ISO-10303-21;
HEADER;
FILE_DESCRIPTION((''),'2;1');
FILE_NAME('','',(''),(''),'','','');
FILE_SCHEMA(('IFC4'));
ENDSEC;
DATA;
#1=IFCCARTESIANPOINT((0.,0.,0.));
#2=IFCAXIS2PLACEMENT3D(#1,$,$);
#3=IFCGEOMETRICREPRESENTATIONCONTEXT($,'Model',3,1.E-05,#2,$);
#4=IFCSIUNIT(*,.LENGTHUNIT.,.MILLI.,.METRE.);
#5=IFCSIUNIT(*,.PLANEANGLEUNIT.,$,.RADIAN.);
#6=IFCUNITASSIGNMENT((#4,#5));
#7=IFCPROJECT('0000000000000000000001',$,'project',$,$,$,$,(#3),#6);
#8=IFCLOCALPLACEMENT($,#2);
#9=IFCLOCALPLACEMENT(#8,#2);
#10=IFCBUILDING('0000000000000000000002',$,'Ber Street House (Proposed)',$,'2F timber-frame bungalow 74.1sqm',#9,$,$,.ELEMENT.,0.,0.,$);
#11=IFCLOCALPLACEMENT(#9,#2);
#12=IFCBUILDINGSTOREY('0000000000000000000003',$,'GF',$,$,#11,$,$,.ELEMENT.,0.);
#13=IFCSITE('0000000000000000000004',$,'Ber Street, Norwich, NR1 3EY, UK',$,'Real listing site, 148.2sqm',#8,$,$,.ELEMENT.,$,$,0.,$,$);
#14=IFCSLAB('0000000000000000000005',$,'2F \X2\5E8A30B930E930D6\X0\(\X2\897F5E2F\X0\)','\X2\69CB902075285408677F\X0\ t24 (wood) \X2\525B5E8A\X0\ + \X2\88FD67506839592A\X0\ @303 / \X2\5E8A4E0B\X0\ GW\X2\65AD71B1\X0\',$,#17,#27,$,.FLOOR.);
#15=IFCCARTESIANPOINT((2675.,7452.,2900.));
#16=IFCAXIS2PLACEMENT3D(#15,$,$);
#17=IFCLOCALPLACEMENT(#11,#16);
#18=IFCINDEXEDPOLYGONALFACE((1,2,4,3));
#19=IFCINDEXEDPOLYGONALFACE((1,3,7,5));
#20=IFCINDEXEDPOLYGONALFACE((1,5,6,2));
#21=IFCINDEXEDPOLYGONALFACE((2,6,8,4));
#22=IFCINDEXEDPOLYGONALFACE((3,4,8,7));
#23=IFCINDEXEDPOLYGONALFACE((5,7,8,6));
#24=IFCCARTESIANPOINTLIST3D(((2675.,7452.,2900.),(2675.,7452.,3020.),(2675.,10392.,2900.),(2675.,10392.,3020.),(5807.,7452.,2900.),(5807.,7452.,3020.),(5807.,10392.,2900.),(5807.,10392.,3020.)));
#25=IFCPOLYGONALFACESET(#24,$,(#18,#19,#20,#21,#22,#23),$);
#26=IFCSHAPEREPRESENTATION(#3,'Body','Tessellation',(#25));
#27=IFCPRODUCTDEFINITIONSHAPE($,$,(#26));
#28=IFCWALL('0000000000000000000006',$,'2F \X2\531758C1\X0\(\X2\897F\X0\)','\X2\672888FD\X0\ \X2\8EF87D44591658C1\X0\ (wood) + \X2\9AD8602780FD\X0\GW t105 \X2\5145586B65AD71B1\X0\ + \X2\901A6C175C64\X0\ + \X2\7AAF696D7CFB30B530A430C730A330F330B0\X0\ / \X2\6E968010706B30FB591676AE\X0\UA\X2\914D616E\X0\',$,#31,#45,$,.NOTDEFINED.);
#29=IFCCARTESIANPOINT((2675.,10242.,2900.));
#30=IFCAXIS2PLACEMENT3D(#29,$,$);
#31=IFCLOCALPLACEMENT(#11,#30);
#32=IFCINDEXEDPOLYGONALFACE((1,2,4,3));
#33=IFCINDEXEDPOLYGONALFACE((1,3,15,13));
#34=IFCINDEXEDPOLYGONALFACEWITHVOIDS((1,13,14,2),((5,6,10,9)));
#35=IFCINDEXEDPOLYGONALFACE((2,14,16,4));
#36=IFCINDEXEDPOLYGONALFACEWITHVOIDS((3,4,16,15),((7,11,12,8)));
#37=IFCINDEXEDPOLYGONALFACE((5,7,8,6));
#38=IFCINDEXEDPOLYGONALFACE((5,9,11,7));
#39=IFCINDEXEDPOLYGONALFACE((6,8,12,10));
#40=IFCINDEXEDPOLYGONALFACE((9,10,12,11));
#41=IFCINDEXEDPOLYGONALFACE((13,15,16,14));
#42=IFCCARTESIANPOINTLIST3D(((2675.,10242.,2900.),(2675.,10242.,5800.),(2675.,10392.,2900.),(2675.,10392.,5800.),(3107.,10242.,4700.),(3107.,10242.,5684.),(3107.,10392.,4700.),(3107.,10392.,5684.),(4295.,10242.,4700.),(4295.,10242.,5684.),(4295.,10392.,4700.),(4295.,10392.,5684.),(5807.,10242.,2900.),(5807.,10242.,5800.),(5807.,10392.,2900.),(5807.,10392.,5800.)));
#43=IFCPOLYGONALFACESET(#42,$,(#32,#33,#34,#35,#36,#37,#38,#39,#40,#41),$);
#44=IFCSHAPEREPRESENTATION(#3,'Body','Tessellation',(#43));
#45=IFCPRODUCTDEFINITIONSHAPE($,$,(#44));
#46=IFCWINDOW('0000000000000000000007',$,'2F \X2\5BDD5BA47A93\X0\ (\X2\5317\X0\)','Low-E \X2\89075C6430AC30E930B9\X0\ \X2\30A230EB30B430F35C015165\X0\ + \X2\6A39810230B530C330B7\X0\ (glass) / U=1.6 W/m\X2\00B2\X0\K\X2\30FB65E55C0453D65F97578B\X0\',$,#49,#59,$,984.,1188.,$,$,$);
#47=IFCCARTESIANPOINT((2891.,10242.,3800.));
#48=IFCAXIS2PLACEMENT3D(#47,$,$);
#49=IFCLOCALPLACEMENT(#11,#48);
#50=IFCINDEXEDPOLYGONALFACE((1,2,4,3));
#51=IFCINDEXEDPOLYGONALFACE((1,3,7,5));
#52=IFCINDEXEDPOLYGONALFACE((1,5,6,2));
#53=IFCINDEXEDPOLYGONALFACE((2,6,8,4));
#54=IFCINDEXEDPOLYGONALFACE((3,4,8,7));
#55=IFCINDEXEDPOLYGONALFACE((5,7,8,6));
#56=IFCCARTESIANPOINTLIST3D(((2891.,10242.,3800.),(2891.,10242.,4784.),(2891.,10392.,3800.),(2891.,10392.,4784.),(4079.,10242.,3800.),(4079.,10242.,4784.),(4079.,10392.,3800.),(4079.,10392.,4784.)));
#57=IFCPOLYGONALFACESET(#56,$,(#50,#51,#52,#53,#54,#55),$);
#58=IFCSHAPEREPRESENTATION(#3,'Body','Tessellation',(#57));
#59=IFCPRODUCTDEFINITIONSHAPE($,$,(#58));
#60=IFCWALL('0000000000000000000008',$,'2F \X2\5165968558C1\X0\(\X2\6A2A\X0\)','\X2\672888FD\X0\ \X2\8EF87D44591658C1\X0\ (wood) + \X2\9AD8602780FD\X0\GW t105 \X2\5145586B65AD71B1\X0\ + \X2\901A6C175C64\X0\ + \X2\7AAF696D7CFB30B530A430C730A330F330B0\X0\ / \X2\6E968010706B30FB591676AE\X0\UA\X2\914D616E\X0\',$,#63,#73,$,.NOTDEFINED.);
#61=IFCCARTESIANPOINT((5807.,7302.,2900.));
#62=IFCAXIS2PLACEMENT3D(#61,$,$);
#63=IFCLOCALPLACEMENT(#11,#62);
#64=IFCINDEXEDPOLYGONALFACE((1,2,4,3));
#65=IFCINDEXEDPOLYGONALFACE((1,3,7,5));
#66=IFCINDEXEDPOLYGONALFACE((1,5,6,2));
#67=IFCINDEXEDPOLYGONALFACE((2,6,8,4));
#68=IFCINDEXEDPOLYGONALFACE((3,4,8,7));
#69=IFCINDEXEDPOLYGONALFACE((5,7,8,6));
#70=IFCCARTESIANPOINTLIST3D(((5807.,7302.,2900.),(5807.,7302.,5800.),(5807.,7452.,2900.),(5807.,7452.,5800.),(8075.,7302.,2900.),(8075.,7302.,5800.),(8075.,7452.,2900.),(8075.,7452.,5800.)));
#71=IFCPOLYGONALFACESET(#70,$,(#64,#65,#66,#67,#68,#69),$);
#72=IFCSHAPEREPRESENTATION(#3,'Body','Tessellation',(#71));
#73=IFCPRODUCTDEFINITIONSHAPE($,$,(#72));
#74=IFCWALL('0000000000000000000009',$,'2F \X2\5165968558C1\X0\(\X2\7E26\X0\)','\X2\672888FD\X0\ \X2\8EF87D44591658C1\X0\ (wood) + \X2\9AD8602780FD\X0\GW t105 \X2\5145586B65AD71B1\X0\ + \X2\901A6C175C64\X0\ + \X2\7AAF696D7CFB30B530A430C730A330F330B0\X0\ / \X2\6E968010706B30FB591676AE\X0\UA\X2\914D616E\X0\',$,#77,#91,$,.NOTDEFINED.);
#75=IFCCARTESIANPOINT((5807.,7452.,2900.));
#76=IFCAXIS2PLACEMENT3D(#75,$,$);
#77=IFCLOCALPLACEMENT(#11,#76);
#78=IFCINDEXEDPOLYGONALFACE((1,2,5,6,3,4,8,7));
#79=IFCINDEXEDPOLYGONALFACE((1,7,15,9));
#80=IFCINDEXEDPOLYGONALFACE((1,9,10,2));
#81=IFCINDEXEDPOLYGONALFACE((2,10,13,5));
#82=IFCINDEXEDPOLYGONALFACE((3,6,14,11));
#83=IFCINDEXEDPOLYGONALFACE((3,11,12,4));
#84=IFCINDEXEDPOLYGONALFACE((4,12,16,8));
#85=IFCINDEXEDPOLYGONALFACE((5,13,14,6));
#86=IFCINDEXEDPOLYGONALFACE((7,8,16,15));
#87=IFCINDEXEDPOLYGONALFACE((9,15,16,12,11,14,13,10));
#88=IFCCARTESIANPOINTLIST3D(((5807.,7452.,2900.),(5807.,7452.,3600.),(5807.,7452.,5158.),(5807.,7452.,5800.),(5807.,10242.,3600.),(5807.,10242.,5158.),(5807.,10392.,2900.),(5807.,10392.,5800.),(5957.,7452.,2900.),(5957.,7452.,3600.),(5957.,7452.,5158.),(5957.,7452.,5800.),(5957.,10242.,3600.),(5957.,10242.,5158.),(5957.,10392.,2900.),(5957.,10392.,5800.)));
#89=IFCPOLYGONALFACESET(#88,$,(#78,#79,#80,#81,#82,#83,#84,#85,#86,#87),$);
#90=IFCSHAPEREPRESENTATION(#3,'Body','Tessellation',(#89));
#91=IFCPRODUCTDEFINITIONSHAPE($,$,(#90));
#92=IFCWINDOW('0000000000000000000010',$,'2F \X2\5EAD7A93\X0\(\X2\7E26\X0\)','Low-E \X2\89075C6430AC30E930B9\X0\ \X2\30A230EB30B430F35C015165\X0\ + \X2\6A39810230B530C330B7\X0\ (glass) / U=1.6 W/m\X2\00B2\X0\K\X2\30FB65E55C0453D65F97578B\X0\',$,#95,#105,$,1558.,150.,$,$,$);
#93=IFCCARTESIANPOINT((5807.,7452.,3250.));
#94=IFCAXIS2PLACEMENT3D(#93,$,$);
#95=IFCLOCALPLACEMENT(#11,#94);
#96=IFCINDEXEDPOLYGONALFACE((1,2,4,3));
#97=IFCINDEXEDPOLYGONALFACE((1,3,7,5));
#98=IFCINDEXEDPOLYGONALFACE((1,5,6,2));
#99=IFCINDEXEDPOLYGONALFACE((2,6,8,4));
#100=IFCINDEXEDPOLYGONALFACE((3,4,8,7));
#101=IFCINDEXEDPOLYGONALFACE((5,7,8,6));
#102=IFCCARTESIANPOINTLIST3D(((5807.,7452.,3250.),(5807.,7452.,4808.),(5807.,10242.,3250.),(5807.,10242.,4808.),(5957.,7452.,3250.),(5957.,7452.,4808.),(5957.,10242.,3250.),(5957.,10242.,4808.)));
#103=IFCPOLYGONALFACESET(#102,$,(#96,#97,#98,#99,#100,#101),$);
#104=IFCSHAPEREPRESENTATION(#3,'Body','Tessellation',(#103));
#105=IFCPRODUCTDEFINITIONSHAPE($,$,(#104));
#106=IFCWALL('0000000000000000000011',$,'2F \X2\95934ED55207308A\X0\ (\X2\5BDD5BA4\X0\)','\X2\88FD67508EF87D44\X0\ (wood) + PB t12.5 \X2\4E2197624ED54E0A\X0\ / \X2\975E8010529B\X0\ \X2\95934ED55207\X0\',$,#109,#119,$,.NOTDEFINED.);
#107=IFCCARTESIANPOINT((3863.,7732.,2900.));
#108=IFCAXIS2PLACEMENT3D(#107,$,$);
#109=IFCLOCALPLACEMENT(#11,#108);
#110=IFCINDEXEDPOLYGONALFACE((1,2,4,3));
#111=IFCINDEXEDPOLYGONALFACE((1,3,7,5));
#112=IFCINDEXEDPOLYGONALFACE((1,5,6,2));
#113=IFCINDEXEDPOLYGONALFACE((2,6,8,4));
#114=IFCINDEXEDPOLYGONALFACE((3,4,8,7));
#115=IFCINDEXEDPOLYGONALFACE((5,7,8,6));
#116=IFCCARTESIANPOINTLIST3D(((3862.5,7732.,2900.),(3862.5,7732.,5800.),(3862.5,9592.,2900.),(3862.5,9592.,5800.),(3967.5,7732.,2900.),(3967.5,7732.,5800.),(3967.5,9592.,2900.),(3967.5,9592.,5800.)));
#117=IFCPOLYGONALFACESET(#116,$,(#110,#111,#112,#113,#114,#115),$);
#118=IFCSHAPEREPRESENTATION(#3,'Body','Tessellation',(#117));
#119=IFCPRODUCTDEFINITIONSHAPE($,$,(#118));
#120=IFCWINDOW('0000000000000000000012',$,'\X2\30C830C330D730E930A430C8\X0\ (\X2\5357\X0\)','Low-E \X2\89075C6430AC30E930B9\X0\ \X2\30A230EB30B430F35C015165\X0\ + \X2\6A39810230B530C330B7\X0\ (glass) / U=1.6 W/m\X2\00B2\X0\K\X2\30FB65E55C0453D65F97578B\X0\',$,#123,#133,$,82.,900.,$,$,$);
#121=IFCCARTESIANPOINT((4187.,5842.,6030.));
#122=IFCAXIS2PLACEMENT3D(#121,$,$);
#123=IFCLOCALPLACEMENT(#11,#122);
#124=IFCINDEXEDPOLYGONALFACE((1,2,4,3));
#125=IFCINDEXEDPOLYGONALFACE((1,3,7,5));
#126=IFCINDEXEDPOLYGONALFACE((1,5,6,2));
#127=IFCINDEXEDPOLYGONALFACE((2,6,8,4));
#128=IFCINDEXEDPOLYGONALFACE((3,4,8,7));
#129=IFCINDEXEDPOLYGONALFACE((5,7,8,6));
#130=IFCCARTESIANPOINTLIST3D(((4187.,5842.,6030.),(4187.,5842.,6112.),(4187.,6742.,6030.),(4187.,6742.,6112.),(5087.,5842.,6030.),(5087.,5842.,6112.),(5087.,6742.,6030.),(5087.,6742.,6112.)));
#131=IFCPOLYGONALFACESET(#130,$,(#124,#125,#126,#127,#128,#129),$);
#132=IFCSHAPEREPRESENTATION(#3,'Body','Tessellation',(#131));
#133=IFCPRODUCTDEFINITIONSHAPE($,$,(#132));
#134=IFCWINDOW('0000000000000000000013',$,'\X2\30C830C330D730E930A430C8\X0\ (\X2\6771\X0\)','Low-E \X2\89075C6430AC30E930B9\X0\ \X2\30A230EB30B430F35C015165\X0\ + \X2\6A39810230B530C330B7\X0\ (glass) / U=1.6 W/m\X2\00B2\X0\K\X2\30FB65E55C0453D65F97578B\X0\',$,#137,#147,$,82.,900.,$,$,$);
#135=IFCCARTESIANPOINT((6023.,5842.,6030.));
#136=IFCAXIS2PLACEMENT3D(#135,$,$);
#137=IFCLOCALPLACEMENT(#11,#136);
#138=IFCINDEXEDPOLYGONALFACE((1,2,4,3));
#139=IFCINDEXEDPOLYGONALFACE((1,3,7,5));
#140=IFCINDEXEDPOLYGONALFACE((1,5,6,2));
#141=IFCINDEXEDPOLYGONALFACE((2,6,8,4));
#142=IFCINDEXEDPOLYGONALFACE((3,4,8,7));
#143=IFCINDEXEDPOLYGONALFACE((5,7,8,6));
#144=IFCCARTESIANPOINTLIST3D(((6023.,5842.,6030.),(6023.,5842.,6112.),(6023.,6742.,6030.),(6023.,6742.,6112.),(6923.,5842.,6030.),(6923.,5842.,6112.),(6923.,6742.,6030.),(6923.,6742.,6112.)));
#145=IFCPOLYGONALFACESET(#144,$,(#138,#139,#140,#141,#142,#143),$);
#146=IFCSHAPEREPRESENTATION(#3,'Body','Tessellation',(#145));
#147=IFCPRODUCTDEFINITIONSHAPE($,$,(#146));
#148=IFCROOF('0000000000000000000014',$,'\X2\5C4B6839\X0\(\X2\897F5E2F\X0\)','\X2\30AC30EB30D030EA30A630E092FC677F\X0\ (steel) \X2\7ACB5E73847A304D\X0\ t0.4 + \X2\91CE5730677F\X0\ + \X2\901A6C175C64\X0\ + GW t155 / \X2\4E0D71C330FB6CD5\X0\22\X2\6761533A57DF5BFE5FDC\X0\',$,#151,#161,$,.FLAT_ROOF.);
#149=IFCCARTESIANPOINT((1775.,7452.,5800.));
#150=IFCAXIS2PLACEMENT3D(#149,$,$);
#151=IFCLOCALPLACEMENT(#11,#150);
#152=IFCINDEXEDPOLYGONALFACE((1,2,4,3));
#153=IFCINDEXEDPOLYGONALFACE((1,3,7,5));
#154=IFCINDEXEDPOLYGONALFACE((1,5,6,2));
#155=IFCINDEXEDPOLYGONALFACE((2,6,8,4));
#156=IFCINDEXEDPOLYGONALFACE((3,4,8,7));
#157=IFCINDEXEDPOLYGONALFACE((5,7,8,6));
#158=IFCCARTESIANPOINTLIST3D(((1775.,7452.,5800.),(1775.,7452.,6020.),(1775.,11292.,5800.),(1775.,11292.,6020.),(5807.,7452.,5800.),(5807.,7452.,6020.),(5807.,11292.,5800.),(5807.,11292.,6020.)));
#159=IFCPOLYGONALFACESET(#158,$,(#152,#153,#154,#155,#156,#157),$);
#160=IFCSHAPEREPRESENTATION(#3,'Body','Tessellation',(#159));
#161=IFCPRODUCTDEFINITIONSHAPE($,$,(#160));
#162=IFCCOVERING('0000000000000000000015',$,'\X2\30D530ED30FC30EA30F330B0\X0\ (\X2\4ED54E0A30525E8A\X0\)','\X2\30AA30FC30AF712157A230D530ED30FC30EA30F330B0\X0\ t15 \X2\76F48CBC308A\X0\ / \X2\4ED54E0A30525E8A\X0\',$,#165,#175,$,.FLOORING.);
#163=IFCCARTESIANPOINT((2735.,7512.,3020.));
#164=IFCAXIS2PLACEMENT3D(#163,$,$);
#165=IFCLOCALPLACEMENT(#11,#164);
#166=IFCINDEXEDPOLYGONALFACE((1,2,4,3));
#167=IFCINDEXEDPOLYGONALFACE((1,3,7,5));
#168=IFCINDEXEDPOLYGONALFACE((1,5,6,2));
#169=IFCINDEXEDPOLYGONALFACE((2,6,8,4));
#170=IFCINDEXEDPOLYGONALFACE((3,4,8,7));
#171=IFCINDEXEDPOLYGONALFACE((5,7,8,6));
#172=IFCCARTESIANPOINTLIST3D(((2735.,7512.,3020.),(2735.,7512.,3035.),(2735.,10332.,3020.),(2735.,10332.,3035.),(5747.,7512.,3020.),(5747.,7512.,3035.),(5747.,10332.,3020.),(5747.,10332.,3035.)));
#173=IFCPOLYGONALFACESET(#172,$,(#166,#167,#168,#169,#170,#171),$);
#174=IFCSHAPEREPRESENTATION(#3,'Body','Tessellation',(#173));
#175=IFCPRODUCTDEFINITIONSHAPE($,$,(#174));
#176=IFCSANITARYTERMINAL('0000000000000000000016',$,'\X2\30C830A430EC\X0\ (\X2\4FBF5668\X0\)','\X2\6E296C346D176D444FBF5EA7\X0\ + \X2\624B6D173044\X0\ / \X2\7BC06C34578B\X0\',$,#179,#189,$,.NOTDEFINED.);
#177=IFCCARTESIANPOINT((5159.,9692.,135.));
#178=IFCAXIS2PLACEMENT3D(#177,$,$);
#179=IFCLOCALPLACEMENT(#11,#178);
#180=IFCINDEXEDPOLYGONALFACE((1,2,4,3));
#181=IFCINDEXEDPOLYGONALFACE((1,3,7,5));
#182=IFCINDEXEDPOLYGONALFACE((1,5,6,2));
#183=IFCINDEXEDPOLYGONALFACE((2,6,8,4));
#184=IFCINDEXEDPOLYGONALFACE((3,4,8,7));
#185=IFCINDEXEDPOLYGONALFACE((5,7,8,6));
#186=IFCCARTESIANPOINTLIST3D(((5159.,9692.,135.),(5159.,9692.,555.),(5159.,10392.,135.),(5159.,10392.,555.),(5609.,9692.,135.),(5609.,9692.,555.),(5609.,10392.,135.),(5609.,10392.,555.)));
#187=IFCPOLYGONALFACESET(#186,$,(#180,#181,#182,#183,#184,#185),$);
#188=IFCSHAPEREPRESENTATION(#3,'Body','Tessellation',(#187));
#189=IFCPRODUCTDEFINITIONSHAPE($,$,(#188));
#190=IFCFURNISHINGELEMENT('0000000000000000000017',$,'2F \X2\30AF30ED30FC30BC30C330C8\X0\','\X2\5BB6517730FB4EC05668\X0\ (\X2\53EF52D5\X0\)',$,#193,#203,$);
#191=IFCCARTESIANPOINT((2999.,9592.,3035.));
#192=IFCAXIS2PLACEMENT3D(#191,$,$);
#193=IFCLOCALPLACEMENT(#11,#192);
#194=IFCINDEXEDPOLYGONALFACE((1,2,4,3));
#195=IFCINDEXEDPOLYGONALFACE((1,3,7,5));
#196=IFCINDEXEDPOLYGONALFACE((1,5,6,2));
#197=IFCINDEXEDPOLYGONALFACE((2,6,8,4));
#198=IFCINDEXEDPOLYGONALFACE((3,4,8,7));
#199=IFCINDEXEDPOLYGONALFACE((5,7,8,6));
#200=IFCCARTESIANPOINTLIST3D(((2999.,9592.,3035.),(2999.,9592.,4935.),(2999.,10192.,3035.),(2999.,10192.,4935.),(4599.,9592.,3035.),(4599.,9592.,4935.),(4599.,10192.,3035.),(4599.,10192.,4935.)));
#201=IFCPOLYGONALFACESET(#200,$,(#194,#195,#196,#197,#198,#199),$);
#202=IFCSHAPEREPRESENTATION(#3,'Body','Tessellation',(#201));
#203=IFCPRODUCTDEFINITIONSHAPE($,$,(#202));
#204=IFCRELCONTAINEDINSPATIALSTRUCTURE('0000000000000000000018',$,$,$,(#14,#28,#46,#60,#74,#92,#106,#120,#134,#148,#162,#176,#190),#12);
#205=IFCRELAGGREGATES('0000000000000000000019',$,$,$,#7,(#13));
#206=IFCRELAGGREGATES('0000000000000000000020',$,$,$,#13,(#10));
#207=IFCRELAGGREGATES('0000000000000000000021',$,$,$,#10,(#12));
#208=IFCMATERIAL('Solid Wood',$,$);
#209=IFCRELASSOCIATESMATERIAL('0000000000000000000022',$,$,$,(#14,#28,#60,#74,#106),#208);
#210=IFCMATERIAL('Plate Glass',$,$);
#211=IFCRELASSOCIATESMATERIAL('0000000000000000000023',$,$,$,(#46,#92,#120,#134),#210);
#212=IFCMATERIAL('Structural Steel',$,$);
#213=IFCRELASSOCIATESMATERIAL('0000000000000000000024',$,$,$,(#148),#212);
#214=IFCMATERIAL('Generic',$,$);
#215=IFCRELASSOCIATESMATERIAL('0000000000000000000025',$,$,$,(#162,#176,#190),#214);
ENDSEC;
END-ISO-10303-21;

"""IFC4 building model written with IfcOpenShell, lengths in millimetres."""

from ifc_helpers import new_model, si_unit, frame, frame_2d, origin, place, context, project, spatial, rectangle, extrude, material, element, fill, save


model = new_model("IFC4")

# Units and contexts
model_context = context("Model", 3, precision=1e-05, world=origin())
ifc_project = project(units=[si_unit("LENGTHUNIT", "METRE", prefix="MILLI"), si_unit("PLANEANGLEUNIT", "RADIAN")], contexts=[model_context])

# Site, building, storey
site_placement = place(None, origin())
site = spatial("IfcSite", under=ifc_project, at=site_placement, Name="Ber Street, Norwich, NR1 3EY, UK", ObjectType="Real listing site, 148.2sqm", CompositionType="ELEMENT", RefElevation=0.0)
building_placement = place(site_placement, origin())
building = spatial("IfcBuilding", under=site, at=building_placement, Name="Ber Street House (Proposed)", ObjectType="2F timber-frame bungalow 74.1sqm", CompositionType="ELEMENT", ElevationOfRefHeight=0.0, ElevationOfTerrain=0.0)
storey_placement = place(building_placement, origin())
storey = spatial("IfcBuildingStorey", under=building, at=storey_placement, Name="GF", CompositionType="ELEMENT", Elevation=0.0)

# Slab
ifc_material_1 = material(Name="Solid Wood")
slab_placement = place(storey_placement, frame((2675.0, 7452.0, 2900.0)))
element("IfcSlab", 1, at=slab_placement, inside=storey, material=ifc_material_1, Name="2F 床スラブ(西帯)", Description="構造用合板 t24 (wood) 剛床 + 製材根太 @303 / 床下 GW断熱", PredefinedType="FLOOR", context=model_context, shape_type="SweptSolid", body=[
    extrude(rectangle(XDim=3132.0, YDim=2940.0, at=frame_2d((1566.0, 1470.0))), frame((2675.0, 7452.0, 2900.0)), (0.0, 0.0, 1.0), 120.0),
])

# Wall, opening, window
wall_1_placement = place(storey_placement, frame((2675.0, 10242.0, 2900.0)))
wall_1 = element("IfcWall", 2, at=wall_1_placement, inside=storey, material=ifc_material_1, Name="2F 北壁(西)", Description="木製 軸組外壁 (wood) + 高性能GW t105 充填断熱 + 通気層 + 窯業系サイディング / 準耐火・外皮UA配慮", PredefinedType="NOTDEFINED", context=model_context, shape_type="SweptSolid", body=[
    extrude(rectangle(XDim=3132.0, YDim=150.0, at=frame_2d((1566.0, 75.0))), frame((2675.0, 10242.0, 2900.0)), (0.0, 0.0, 1.0), 2900.0),
])
opening_1_placement = place(storey_placement, frame((2891.0, 10242.0, 3800.0)))
opening_1 = element("IfcOpeningElement", 3, at=opening_1_placement, cuts=wall_1, PredefinedType="NOTDEFINED", context=model_context, shape_type="SweptSolid", body=[
    extrude(rectangle(XDim=1188.0, YDim=150.0, at=frame_2d((594.0, 75.0))), frame((2891.0, 10242.0, 3800.0)), (0.0, 0.0, 1.0), 984.0),
])
ifc_material_2 = material(Name="Plate Glass")
window_1_placement = place(storey_placement, frame((2891.0, 10242.0, 3800.0)))
window_1 = element("IfcWindow", 4, at=window_1_placement, inside=storey, material=ifc_material_2, Name="2F 寝室窓 (北)", Description="Low-E 複層ガラス アルゴン封入 + 樹脂サッシ (glass) / U=1.6 W/m²K・日射取得型", OverallHeight=984.0, OverallWidth=1188.0, context=model_context, shape_type="SweptSolid", body=[
    extrude(rectangle(XDim=1188.0, YDim=150.0, at=frame_2d((594.0, 75.0))), frame((2891.0, 10242.0, 3800.0)), (0.0, 0.0, 1.0), 984.0),
])
fill(opening_1, window_1)

# Wall
wall_2_placement = place(storey_placement, frame((5807.0, 7302.0, 2900.0)))
element("IfcWall", 5, at=wall_2_placement, inside=storey, material=ifc_material_1, Name="2F 入隅壁(横)", Description="木製 軸組外壁 (wood) + 高性能GW t105 充填断熱 + 通気層 + 窯業系サイディング / 準耐火・外皮UA配慮", PredefinedType="NOTDEFINED", context=model_context, shape_type="SweptSolid", body=[
    extrude(rectangle(XDim=2268.0, YDim=150.0, at=frame_2d((1134.0, 75.0))), frame((5807.0, 7302.0, 2900.0)), (0.0, 0.0, 1.0), 2900.0),
])

# Wall, opening, window
wall_3_placement = place(storey_placement, frame((5807.0, 7452.0, 2900.0)))
wall_3 = element("IfcWall", 6, at=wall_3_placement, inside=storey, material=ifc_material_1, Name="2F 入隅壁(縦)", Description="木製 軸組外壁 (wood) + 高性能GW t105 充填断熱 + 通気層 + 窯業系サイディング / 準耐火・外皮UA配慮", PredefinedType="NOTDEFINED", context=model_context, shape_type="SweptSolid", body=[
    extrude(rectangle(XDim=150.0, YDim=2940.0, at=frame_2d((75.0, 1470.0))), frame((5807.0, 7452.0, 2900.0)), (0.0, 0.0, 1.0), 2900.0),
])
opening_2_placement = place(storey_placement, frame((5807.0, 7452.0, 3250.0)))
opening_2 = element("IfcOpeningElement", 7, at=opening_2_placement, cuts=wall_3, PredefinedType="NOTDEFINED", context=model_context, shape_type="SweptSolid", body=[
    extrude(rectangle(XDim=150.0, YDim=2790.0, at=frame_2d((75.0, 1395.0))), frame((5807.0, 7452.0, 3250.0)), (0.0, 0.0, 1.0), 1558.0),
])
window_2_placement = place(storey_placement, frame((5807.0, 7452.0, 3250.0)))
window_2 = element("IfcWindow", 8, at=window_2_placement, inside=storey, material=ifc_material_2, Name="2F 庭窓(縦)", Description="Low-E 複層ガラス アルゴン封入 + 樹脂サッシ (glass) / U=1.6 W/m²K・日射取得型", OverallHeight=1558.0, OverallWidth=150.0, context=model_context, shape_type="SweptSolid", body=[
    extrude(rectangle(XDim=150.0, YDim=2790.0, at=frame_2d((75.0, 1395.0))), frame((5807.0, 7452.0, 3250.0)), (0.0, 0.0, 1.0), 1558.0),
])
fill(opening_2, window_2)

# Wall
wall_4_placement = place(storey_placement, frame((3863.0, 7732.0, 2900.0)))
element("IfcWall", 9, at=wall_4_placement, inside=storey, material=ifc_material_1, Name="2F 間仕切り (寝室)", Description="製材軸組 (wood) + PB t12.5 両面仕上 / 非耐力 間仕切", PredefinedType="NOTDEFINED", context=model_context, shape_type="SweptSolid", body=[
    extrude(rectangle(XDim=105.0, YDim=1860.0, at=frame_2d((52.0, 930.0))), frame((3863.0, 7732.0, 2900.0)), (0.0, 0.0, 1.0), 2900.0),
])

# Windows
window_3_placement = place(storey_placement, frame((4187.0, 5842.0, 6030.0)))
element("IfcWindow", 10, at=window_3_placement, inside=storey, material=ifc_material_2, Name="トップライト (南)", Description="Low-E 複層ガラス アルゴン封入 + 樹脂サッシ (glass) / U=1.6 W/m²K・日射取得型", OverallHeight=82.0, OverallWidth=900.0, context=model_context, shape_type="SweptSolid", body=[
    extrude(rectangle(XDim=900.0, YDim=900.0, at=frame_2d((450.0, 450.0))), frame((4187.0, 5842.0, 6030.0)), (0.0, 0.0, 1.0), 82.0),
])
window_4_placement = place(storey_placement, frame((6023.0, 5842.0, 6030.0)))
element("IfcWindow", 11, at=window_4_placement, inside=storey, material=ifc_material_2, Name="トップライト (東)", Description="Low-E 複層ガラス アルゴン封入 + 樹脂サッシ (glass) / U=1.6 W/m²K・日射取得型", OverallHeight=82.0, OverallWidth=900.0, context=model_context, shape_type="SweptSolid", body=[
    extrude(rectangle(XDim=900.0, YDim=900.0, at=frame_2d((450.0, 450.0))), frame((6023.0, 5842.0, 6030.0)), (0.0, 0.0, 1.0), 82.0),
])

# Roof
ifc_material_3 = material(Name="Structural Steel")
for number, where, name in (
    (12, (1775.0, 7452.0, 5800.0), "屋根(西帯)"),
):
    element("IfcRoof", number, at=place(storey_placement, frame(where)), inside=storey, material=ifc_material_3, Name=name, Description="ガルバリウム鋼板 (steel) 立平葺き t0.4 + 野地板 + 通気層 + GW t155 / 不燃・法22条区域対応", PredefinedType="FLAT_ROOF", context=model_context, shape_type="SweptSolid", body=[
        extrude(rectangle(XDim=4032.0, YDim=3840.0, at=frame_2d((2016.0, 1920.0))), frame((1775.0, 7452.0, 5800.0)), (0.0, 0.0, 1.0), 220.0),
    ])

# Covering
ifc_material_4 = material(Name="Generic")
covering_placement = place(storey_placement, frame((2735.0, 7512.0, 3020.0)))
element("IfcCovering", 13, at=covering_placement, inside=storey, material=ifc_material_4, Name="フローリング (仕上げ床)", Description="オーク無垢フローリング t15 直貼り / 仕上げ床", PredefinedType="FLOORING", context=model_context, shape_type="SweptSolid", body=[
    extrude(rectangle(XDim=3012.0, YDim=2820.0, at=frame_2d((1506.0, 1410.0))), frame((2735.0, 7512.0, 3020.0)), (0.0, 0.0, 1.0), 15.0),
])

# Sanitary terminal
sanitary_terminal_placement = place(storey_placement, frame((5159.0, 9692.0, 135.0)))
element("IfcSanitaryTerminal", 14, at=sanitary_terminal_placement, inside=storey, material=ifc_material_4, Name="トイレ (便器)", Description="温水洗浄便座 + 手洗い / 節水型", PredefinedType="NOTDEFINED", context=model_context, shape_type="SweptSolid", body=[
    extrude(rectangle(XDim=450.0, YDim=700.0, at=frame_2d((225.0, 350.0))), frame((5159.0, 9692.0, 135.0)), (0.0, 0.0, 1.0), 420.0),
])

# Furnishing element
furnishing_1_placement = place(storey_placement, frame((2999.0, 9592.0, 3035.0)))
element("IfcFurnishingElement", 15, at=furnishing_1_placement, inside=storey, material=ifc_material_4, Name="2F クローゼット", Description="家具・什器 (可動)", context=model_context, shape_type="SweptSolid", body=[
    extrude(rectangle(XDim=1600.0, YDim=600.0, at=frame_2d((800.0, 300.0))), frame((2999.0, 9592.0, 3035.0)), (0.0, 0.0, 1.0), 1900.0),
])

save(model, "model.ifc")
